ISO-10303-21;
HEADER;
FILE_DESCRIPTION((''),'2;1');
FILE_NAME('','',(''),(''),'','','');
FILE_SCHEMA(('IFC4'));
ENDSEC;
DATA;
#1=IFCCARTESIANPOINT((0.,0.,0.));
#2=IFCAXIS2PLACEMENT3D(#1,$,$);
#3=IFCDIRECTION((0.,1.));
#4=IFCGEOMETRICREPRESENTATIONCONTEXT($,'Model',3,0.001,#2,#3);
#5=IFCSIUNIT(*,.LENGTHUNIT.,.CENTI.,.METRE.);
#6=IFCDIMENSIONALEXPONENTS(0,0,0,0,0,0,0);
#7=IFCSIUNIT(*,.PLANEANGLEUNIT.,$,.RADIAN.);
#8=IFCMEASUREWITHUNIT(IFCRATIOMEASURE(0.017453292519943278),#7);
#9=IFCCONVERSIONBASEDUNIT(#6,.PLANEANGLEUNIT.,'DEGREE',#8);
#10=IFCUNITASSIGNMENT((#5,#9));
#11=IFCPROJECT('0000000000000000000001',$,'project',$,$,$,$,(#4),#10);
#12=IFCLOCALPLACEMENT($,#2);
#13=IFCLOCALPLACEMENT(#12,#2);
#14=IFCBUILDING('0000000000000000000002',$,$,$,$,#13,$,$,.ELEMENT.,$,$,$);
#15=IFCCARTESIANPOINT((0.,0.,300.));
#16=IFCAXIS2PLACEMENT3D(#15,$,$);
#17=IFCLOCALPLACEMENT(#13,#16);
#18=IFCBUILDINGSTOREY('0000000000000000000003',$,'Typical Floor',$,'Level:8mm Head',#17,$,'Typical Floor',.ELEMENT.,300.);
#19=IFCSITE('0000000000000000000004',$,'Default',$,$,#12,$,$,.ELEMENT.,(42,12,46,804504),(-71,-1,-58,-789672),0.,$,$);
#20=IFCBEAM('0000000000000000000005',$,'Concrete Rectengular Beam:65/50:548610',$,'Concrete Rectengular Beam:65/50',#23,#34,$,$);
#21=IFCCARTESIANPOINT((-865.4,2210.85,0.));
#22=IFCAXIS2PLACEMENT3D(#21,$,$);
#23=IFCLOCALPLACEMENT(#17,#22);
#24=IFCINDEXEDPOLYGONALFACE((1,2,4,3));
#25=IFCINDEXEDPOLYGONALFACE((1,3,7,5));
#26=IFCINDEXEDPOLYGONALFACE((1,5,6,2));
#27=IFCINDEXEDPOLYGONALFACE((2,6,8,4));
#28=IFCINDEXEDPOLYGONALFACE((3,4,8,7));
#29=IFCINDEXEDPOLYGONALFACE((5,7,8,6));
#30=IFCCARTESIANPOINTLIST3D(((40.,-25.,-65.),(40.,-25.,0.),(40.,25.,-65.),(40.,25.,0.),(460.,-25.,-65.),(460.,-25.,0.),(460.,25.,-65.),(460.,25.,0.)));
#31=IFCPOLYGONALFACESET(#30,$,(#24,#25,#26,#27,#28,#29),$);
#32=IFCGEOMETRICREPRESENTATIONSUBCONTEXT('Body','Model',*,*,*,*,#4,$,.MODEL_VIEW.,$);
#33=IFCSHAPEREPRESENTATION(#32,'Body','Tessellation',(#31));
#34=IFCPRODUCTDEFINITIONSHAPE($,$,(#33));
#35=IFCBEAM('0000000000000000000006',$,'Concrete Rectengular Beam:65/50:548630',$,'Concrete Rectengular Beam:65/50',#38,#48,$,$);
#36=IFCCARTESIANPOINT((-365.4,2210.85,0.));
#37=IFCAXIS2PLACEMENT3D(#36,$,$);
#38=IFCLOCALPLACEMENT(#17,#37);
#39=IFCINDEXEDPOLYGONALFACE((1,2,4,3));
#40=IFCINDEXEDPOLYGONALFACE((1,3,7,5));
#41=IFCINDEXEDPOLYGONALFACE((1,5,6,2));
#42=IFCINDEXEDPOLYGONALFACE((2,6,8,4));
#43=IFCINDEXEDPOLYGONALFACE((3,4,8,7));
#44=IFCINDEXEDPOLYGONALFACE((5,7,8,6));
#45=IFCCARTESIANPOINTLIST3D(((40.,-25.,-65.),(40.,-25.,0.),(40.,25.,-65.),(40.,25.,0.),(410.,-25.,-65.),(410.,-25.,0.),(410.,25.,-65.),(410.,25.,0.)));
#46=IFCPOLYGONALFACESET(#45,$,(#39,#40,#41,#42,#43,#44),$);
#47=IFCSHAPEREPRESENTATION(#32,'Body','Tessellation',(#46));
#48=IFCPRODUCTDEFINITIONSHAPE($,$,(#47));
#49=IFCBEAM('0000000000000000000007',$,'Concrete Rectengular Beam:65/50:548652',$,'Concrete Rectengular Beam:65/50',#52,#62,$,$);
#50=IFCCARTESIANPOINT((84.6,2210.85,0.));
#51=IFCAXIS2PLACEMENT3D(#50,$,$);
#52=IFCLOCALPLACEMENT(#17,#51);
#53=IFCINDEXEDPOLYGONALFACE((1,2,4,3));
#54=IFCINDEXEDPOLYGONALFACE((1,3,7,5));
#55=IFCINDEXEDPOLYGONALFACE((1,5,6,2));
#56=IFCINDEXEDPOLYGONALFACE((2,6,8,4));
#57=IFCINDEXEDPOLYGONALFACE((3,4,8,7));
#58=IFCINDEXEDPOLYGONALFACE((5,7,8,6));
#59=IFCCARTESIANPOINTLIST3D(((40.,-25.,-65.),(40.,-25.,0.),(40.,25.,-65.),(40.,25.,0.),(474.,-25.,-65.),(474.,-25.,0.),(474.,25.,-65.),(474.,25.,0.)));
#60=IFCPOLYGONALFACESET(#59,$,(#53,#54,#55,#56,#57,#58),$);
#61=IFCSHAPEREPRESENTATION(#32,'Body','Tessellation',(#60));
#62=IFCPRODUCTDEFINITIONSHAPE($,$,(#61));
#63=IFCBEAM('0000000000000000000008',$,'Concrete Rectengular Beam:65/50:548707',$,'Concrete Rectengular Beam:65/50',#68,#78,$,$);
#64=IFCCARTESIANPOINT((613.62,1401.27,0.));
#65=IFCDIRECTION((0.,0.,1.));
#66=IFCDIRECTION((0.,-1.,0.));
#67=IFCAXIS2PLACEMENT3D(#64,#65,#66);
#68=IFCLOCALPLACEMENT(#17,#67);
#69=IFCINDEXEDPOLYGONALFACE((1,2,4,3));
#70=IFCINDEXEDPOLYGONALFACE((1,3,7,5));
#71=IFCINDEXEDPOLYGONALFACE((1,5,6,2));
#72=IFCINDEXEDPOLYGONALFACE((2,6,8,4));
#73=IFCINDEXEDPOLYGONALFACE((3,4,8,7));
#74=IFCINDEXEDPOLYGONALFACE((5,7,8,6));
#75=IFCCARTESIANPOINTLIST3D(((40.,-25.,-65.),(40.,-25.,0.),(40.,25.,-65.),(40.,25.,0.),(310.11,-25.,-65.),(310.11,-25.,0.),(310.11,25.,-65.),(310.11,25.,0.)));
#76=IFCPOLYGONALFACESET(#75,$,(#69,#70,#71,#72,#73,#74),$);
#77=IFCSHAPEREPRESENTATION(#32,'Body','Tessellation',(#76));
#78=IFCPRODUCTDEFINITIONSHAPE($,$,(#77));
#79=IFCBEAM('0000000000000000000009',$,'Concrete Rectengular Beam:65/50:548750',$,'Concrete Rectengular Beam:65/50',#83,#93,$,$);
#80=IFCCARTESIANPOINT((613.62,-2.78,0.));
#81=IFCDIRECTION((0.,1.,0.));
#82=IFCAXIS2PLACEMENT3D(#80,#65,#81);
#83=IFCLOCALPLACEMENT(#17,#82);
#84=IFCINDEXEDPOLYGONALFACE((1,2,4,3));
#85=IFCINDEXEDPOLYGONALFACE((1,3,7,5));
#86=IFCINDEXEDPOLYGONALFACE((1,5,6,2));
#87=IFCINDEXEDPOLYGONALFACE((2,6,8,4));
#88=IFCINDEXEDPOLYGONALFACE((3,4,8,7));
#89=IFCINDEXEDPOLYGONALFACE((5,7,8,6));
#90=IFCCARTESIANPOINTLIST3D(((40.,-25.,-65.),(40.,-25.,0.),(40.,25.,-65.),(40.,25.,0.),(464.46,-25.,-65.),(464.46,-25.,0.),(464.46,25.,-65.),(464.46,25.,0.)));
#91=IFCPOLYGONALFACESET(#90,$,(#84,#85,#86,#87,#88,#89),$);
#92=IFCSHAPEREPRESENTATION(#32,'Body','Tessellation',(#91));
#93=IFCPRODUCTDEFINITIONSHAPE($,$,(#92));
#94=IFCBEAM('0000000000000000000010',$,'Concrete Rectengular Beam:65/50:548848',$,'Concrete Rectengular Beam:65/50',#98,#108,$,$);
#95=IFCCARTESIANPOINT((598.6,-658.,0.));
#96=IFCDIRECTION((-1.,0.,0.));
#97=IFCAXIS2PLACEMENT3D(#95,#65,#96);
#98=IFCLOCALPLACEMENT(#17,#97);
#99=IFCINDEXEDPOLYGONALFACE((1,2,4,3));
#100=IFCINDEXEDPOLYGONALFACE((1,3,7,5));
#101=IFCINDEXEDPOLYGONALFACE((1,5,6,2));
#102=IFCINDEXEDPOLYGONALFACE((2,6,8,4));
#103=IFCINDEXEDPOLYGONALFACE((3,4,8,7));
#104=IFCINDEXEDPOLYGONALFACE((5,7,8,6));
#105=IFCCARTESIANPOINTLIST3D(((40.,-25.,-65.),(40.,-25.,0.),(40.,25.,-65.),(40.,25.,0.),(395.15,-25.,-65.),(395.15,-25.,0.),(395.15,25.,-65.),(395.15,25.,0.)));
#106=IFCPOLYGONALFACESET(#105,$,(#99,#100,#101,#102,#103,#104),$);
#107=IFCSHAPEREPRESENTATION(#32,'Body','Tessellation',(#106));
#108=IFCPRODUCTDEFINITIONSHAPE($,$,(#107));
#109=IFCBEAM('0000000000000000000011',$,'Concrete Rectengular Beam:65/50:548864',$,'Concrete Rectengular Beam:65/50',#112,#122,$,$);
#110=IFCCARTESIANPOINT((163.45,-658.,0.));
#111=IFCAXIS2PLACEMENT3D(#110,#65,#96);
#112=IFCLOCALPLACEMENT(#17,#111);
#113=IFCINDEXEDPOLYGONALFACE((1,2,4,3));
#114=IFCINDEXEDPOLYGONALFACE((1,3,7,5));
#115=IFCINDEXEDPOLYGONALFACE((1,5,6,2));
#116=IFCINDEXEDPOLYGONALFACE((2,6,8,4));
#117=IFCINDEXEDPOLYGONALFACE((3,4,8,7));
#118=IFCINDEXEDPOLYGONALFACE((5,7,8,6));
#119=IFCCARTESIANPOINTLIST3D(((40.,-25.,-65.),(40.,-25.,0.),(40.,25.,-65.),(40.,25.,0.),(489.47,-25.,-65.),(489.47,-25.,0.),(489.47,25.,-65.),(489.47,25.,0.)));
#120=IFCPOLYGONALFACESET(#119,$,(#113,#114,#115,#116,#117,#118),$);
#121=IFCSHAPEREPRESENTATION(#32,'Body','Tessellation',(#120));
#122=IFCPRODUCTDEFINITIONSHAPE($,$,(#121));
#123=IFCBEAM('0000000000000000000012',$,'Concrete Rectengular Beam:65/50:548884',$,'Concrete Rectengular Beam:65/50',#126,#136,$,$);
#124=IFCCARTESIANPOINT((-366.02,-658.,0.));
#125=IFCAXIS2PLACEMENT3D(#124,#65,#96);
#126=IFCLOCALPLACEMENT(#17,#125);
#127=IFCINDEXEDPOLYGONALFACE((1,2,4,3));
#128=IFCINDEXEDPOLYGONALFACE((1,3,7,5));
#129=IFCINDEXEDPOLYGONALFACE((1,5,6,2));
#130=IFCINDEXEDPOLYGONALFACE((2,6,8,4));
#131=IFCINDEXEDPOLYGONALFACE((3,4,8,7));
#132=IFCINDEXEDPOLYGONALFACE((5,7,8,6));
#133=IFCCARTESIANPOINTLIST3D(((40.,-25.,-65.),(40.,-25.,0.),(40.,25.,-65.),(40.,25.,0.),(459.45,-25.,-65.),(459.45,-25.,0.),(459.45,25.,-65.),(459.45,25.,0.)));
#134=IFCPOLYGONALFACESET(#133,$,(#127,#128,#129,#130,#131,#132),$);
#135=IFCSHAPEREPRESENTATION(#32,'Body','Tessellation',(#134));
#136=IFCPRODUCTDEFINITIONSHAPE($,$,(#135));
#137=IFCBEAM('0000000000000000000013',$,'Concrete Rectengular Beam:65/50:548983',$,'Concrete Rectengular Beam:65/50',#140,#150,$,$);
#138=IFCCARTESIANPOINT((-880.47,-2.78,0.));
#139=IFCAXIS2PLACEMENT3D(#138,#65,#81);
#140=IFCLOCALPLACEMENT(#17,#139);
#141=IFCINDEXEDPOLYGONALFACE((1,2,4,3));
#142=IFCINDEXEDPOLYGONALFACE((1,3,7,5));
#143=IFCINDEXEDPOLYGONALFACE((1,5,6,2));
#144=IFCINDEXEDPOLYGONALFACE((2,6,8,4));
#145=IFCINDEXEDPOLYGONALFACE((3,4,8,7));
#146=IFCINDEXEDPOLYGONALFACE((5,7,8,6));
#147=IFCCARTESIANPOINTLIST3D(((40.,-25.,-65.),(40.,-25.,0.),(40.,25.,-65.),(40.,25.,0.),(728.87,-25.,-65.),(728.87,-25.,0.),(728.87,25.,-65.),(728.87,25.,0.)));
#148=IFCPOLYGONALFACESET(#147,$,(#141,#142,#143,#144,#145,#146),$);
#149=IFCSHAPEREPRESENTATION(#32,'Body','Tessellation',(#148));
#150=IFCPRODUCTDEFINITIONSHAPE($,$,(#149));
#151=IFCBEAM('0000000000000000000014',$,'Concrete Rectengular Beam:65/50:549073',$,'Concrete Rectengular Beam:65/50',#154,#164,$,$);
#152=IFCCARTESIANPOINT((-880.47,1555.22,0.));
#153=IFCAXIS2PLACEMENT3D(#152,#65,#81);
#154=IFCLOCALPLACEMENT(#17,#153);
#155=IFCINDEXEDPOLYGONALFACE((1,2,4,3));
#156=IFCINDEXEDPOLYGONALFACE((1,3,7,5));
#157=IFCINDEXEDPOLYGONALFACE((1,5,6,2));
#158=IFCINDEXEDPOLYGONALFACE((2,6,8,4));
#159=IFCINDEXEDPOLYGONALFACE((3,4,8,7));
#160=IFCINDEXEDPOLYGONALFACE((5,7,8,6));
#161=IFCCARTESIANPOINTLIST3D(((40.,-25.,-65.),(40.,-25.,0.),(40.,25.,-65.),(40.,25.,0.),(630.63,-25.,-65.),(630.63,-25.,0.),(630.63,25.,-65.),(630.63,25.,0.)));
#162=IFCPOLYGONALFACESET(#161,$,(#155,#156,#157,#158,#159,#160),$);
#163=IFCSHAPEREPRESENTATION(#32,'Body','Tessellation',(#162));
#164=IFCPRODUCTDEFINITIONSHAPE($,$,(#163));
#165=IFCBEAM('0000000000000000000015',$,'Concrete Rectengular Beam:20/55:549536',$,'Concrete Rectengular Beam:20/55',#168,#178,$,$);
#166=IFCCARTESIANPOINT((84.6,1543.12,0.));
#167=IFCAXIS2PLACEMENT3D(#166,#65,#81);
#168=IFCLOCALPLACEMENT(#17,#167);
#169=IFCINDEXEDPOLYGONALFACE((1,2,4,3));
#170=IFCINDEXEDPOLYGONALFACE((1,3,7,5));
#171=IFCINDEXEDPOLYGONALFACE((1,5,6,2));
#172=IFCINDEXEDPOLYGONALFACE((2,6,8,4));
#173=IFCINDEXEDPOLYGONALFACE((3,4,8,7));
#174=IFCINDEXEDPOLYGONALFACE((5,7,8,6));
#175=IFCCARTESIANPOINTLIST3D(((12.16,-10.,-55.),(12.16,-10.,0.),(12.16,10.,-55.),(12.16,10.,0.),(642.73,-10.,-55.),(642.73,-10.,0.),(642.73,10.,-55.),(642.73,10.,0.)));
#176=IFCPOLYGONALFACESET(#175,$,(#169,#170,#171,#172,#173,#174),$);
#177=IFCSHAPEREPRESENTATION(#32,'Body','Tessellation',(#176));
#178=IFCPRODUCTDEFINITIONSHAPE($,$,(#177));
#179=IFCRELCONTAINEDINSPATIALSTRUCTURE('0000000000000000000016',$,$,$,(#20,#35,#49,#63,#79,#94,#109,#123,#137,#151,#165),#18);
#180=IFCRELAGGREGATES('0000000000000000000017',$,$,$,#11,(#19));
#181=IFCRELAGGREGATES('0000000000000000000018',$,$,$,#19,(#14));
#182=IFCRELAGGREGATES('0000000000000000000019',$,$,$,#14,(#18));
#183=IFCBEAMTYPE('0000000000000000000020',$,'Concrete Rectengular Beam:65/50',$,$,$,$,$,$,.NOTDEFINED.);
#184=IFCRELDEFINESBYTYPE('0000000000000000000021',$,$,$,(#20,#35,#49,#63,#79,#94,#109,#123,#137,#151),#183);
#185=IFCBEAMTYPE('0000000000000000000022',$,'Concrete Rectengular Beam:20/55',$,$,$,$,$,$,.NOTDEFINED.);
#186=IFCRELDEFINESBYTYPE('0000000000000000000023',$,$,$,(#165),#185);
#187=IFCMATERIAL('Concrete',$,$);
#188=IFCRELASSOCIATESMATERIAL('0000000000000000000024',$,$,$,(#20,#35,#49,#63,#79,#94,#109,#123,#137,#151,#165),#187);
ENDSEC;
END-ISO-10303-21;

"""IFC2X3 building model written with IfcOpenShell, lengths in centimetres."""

from ifc_helpers import new_model, entity, si_unit, converted_unit, direction, frame, frame_2d, origin, place, context, subcontext, project, spatial, rectangle, extrude, material, type_object, element, save


model = new_model("IFC2X3")

# Units and contexts
model_context = context("Model", 3, precision=0.001, world=origin(), true_north=direction((0.0, 1.0)))
body_context = subcontext(model_context, "Body", "Model", "MODEL_VIEW")
ifc_project = project(units=[si_unit("LENGTHUNIT", "METRE", prefix="CENTI"), converted_unit("PLANEANGLEUNIT", "DEGREE", entity("IfcRatioMeasure", 0.017453292519943278), si_unit("PLANEANGLEUNIT", "RADIAN"), dimensions=[0, 0, 0, 0, 0, 0, 0])], contexts=[model_context])

# Site, building, storey
site_placement = place(None, origin())
site = spatial("IfcSite", under=ifc_project, at=site_placement, Name="Default", CompositionType="ELEMENT", RefLatitude=(42, 12, 46, 804504), RefLongitude=(-71, -1, -58, -789672), RefElevation=0.0)
building_placement = place(site_placement, origin())
building = spatial("IfcBuilding", under=site, at=building_placement, CompositionType="ELEMENT")
storey_placement = place(building_placement, frame((0.0, 0.0, 300.0)))
storey = spatial("IfcBuildingStorey", under=building, at=storey_placement, Name="Typical Floor", ObjectType="Level:8mm Head", LongName="Typical Floor", CompositionType="ELEMENT", Elevation=300.0)

# Beams
ifc_material = material(Name="Concrete")
beam_type_1 = type_object("IfcBeamType", Name="Concrete Rectengular Beam:65/50", PredefinedType="NOTDEFINED")
beam_1_placement = place(storey_placement, frame((-865.4, 2210.85, 0.0)))
element("IfcBeam", 1, at=beam_1_placement, inside=storey, type_object=beam_type_1, material=ifc_material, Name="Concrete Rectengular Beam:65/50:548610", ObjectType="Concrete Rectengular Beam:65/50", context=body_context, shape_type="SweptSolid", body=[
    extrude(rectangle(XDim=65.0, YDim=50.0, at=frame_2d((0.0, 0.0), x_axis=(1.0, 0.0))), frame((40.0, 0.0, -32.5), z_axis=(1.0, 0.0, 0.0), x_axis=(0.0, 0.0, -1.0)), (0.0, 0.0, 1.0), 420.0),
])
beam_2_placement = place(storey_placement, frame((-365.4, 2210.85, 0.0)))
element("IfcBeam", 2, at=beam_2_placement, inside=storey, type_object=beam_type_1, material=ifc_material, Name="Concrete Rectengular Beam:65/50:548630", ObjectType="Concrete Rectengular Beam:65/50", context=body_context, shape_type="SweptSolid", body=[
    extrude(rectangle(XDim=65.0, YDim=50.0, at=frame_2d((0.0, 0.0), x_axis=(1.0, 0.0))), frame((40.0, 0.0, -32.5), z_axis=(1.0, 0.0, 0.0), x_axis=(0.0, 0.0, -1.0)), (0.0, 0.0, 1.0), 370.0),
])
beam_3_placement = place(storey_placement, frame((84.6, 2210.85, 0.0)))
element("IfcBeam", 3, at=beam_3_placement, inside=storey, type_object=beam_type_1, material=ifc_material, Name="Concrete Rectengular Beam:65/50:548652", ObjectType="Concrete Rectengular Beam:65/50", context=body_context, shape_type="SweptSolid", body=[
    extrude(rectangle(XDim=65.0, YDim=50.0, at=frame_2d((0.0, 0.0), x_axis=(1.0, 0.0))), frame((40.0, 0.0, -32.5), z_axis=(1.0, 0.0, 0.0), x_axis=(0.0, 0.0, -1.0)), (0.0, 0.0, 1.0), 434.0),
])
beam_4_placement = place(storey_placement, frame((613.62, 1401.27, 0.0), z_axis=(0.0, 0.0, 1.0), x_axis=(0.0, -1.0, 0.0)))
element("IfcBeam", 4, at=beam_4_placement, inside=storey, type_object=beam_type_1, material=ifc_material, Name="Concrete Rectengular Beam:65/50:548707", ObjectType="Concrete Rectengular Beam:65/50", context=body_context, shape_type="SweptSolid", body=[
    extrude(rectangle(XDim=65.0, YDim=50.0, at=frame_2d((0.0, 0.0), x_axis=(1.0, 0.0))), frame((40.0, 0.0, -32.5), z_axis=(1.0, 0.0, 0.0), x_axis=(0.0, 0.0, -1.0)), (0.0, 0.0, 1.0), 270.11),
])
beam_5_placement = place(storey_placement, frame((613.62, -2.78, 0.0), z_axis=(0.0, 0.0, 1.0), x_axis=(0.0, 1.0, 0.0)))
element("IfcBeam", 5, at=beam_5_placement, inside=storey, type_object=beam_type_1, material=ifc_material, Name="Concrete Rectengular Beam:65/50:548750", ObjectType="Concrete Rectengular Beam:65/50", context=body_context, shape_type="SweptSolid", body=[
    extrude(rectangle(XDim=65.0, YDim=50.0, at=frame_2d((0.0, 0.0), x_axis=(1.0, 0.0))), frame((40.0, 0.0, -32.5), z_axis=(1.0, 0.0, 0.0), x_axis=(0.0, 0.0, -1.0)), (0.0, 0.0, 1.0), 424.46),
])
beam_6_placement = place(storey_placement, frame((598.6, -658.0, 0.0), z_axis=(0.0, 0.0, 1.0), x_axis=(-1.0, 0.0, 0.0)))
element("IfcBeam", 6, at=beam_6_placement, inside=storey, type_object=beam_type_1, material=ifc_material, Name="Concrete Rectengular Beam:65/50:548848", ObjectType="Concrete Rectengular Beam:65/50", context=body_context, shape_type="SweptSolid", body=[
    extrude(rectangle(XDim=65.0, YDim=50.0, at=frame_2d((0.0, 0.0), x_axis=(1.0, 0.0))), frame((40.0, 0.0, -32.5), z_axis=(1.0, 0.0, 0.0), x_axis=(0.0, 0.0, -1.0)), (0.0, 0.0, 1.0), 355.15),
])
beam_7_placement = place(storey_placement, frame((163.45, -658.0, 0.0), z_axis=(0.0, 0.0, 1.0), x_axis=(-1.0, 0.0, 0.0)))
element("IfcBeam", 7, at=beam_7_placement, inside=storey, type_object=beam_type_1, material=ifc_material, Name="Concrete Rectengular Beam:65/50:548864", ObjectType="Concrete Rectengular Beam:65/50", context=body_context, shape_type="SweptSolid", body=[
    extrude(rectangle(XDim=65.0, YDim=50.0, at=frame_2d((0.0, 0.0), x_axis=(1.0, 0.0))), frame((40.0, 0.0, -32.5), z_axis=(1.0, 0.0, 0.0), x_axis=(0.0, 0.0, -1.0)), (0.0, 0.0, 1.0), 449.47),
])
beam_8_placement = place(storey_placement, frame((-366.02, -658.0, 0.0), z_axis=(0.0, 0.0, 1.0), x_axis=(-1.0, 0.0, 0.0)))
element("IfcBeam", 8, at=beam_8_placement, inside=storey, type_object=beam_type_1, material=ifc_material, Name="Concrete Rectengular Beam:65/50:548884", ObjectType="Concrete Rectengular Beam:65/50", context=body_context, shape_type="SweptSolid", body=[
    extrude(rectangle(XDim=65.0, YDim=50.0, at=frame_2d((0.0, 0.0), x_axis=(1.0, 0.0))), frame((40.0, 0.0, -32.5), z_axis=(1.0, 0.0, 0.0), x_axis=(0.0, 0.0, -1.0)), (0.0, 0.0, 1.0), 419.45),
])
beam_9_placement = place(storey_placement, frame((-880.47, -2.78, 0.0), z_axis=(0.0, 0.0, 1.0), x_axis=(0.0, 1.0, 0.0)))
element("IfcBeam", 9, at=beam_9_placement, inside=storey, type_object=beam_type_1, material=ifc_material, Name="Concrete Rectengular Beam:65/50:548983", ObjectType="Concrete Rectengular Beam:65/50", context=body_context, shape_type="SweptSolid", body=[
    extrude(rectangle(XDim=65.0, YDim=50.0, at=frame_2d((0.0, 0.0), x_axis=(1.0, 0.0))), frame((40.0, 0.0, -32.5), z_axis=(1.0, 0.0, 0.0), x_axis=(0.0, 0.0, -1.0)), (0.0, 0.0, 1.0), 688.87),
])
beam_10_placement = place(storey_placement, frame((-880.47, 1555.22, 0.0), z_axis=(0.0, 0.0, 1.0), x_axis=(0.0, 1.0, 0.0)))
element("IfcBeam", 10, at=beam_10_placement, inside=storey, type_object=beam_type_1, material=ifc_material, Name="Concrete Rectengular Beam:65/50:549073", ObjectType="Concrete Rectengular Beam:65/50", context=body_context, shape_type="SweptSolid", body=[
    extrude(rectangle(XDim=65.0, YDim=50.0, at=frame_2d((0.0, 0.0), x_axis=(1.0, 0.0))), frame((40.0, 0.0, -32.5), z_axis=(1.0, 0.0, 0.0), x_axis=(0.0, 0.0, -1.0)), (0.0, 0.0, 1.0), 590.63),
])
beam_type_2 = type_object("IfcBeamType", Name="Concrete Rectengular Beam:20/55", PredefinedType="NOTDEFINED")
beam_11_placement = place(storey_placement, frame((84.6, 1543.12, 0.0), z_axis=(0.0, 0.0, 1.0), x_axis=(0.0, 1.0, 0.0)))
element("IfcBeam", 11, at=beam_11_placement, inside=storey, type_object=beam_type_2, material=ifc_material, Name="Concrete Rectengular Beam:20/55:549536", ObjectType="Concrete Rectengular Beam:20/55", context=body_context, shape_type="SweptSolid", body=[
    extrude(rectangle(XDim=55.0, YDim=20.0, at=frame_2d((0.0, 0.0), x_axis=(1.0, 0.0))), frame((12.16, 0.0, -27.5), z_axis=(1.0, 0.0, 0.0), x_axis=(0.0, 0.0, -1.0)), (0.0, 0.0, 1.0), 630.57),
])

save(model, "model.ifc")
